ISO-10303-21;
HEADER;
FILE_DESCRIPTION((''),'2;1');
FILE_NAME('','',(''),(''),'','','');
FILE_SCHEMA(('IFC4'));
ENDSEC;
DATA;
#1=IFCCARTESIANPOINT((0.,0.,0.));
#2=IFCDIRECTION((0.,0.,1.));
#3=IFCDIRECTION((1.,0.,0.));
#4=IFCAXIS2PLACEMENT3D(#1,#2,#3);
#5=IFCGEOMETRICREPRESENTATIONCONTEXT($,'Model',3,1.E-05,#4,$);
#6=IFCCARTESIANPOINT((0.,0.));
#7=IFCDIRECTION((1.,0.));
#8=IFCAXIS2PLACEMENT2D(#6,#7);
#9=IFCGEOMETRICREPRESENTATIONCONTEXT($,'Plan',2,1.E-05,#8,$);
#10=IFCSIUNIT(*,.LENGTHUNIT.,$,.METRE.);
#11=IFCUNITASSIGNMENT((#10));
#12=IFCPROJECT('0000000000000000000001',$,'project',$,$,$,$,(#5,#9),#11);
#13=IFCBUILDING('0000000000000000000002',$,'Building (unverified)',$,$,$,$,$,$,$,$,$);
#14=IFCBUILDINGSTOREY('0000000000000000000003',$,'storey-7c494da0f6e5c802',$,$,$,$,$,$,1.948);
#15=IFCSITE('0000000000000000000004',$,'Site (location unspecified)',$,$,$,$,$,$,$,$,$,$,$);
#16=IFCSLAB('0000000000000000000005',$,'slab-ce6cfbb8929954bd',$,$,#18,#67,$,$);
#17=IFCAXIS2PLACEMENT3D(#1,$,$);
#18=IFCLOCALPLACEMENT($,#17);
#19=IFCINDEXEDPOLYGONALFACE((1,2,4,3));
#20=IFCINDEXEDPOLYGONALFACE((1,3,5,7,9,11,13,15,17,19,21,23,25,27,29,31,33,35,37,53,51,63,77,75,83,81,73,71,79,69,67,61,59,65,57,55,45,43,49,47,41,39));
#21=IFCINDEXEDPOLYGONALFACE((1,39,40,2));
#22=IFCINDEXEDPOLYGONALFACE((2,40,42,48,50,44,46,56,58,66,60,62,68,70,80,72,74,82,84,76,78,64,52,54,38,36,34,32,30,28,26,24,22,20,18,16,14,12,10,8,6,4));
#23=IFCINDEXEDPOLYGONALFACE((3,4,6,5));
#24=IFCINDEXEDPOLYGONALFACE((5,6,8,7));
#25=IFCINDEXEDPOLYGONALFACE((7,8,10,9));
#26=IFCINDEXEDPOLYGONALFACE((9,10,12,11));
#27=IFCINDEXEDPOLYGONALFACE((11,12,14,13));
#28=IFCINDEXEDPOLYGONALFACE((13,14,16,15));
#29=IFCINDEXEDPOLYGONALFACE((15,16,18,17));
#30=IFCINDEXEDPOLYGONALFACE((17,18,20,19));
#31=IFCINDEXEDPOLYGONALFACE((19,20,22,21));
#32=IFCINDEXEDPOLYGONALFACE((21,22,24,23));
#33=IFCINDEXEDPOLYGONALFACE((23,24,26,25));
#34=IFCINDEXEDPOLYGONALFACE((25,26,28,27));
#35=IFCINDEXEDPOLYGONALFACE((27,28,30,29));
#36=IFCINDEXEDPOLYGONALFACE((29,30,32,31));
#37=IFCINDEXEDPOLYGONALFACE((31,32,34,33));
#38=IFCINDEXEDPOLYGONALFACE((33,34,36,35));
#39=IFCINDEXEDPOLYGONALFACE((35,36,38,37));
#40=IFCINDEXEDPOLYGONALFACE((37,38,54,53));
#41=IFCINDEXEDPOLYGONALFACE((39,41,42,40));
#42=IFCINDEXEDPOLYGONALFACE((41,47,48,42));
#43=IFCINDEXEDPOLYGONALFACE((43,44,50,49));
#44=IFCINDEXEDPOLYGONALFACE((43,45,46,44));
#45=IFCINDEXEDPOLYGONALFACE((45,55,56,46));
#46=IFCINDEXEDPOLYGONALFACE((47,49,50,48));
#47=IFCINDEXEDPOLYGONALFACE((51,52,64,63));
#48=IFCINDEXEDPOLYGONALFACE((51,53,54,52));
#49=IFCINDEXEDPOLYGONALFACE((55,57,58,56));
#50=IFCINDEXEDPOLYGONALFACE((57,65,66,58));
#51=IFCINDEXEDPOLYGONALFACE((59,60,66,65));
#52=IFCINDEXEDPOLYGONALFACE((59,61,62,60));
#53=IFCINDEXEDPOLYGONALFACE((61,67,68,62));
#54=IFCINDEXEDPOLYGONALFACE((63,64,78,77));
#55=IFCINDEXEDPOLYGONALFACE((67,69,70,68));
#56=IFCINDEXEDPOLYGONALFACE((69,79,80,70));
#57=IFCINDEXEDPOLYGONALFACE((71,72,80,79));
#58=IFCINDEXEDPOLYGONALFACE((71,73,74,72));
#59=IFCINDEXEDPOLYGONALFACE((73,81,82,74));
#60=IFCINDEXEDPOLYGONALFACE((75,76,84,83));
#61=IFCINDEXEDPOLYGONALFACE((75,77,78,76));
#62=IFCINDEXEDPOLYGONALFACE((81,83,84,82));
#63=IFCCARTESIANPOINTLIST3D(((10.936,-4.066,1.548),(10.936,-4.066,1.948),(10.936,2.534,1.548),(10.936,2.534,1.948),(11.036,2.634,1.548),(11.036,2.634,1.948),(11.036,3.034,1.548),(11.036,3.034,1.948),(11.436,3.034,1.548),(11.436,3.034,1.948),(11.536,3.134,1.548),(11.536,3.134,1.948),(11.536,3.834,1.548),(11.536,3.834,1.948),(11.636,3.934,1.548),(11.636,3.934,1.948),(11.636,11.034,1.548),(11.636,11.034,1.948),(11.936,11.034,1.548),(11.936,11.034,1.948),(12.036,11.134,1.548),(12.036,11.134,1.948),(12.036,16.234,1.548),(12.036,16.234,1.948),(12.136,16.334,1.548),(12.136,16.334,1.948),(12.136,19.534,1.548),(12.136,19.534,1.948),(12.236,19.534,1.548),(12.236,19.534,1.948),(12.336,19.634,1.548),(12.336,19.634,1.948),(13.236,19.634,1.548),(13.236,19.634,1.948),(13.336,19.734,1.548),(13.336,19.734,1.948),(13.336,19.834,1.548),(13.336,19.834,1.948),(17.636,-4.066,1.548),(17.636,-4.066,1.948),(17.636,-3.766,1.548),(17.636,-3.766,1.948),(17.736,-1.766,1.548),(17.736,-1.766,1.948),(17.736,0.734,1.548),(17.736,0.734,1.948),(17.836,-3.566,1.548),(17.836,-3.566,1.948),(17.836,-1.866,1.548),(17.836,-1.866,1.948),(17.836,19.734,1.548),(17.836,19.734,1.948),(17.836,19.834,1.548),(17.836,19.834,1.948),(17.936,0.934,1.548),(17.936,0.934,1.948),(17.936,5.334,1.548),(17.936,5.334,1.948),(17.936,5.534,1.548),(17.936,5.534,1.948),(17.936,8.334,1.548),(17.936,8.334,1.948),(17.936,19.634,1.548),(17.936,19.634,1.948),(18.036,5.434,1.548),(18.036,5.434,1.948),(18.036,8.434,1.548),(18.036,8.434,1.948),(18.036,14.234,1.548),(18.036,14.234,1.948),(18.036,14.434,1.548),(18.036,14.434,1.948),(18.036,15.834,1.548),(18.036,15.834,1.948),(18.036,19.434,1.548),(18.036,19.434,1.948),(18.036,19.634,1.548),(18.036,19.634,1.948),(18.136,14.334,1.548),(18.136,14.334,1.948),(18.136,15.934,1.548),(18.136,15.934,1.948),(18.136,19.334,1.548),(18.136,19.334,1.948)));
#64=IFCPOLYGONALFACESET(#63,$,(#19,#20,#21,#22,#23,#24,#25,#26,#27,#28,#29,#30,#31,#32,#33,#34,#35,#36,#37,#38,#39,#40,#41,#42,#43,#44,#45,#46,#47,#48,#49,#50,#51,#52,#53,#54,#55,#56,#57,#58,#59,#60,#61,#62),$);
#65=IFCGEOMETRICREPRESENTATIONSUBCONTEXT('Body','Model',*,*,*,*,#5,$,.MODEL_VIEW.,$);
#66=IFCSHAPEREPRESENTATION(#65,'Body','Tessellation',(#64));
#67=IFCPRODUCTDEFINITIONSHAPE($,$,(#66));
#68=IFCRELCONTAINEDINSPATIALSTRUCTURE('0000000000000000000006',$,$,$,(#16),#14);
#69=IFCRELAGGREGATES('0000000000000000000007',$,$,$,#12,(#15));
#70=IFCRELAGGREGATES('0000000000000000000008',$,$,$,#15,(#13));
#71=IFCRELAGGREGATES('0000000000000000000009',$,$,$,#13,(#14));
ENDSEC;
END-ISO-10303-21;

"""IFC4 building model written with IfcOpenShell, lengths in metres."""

from ifc_helpers import new_model, si_unit, frame, origin_with_axes, origin_2d_with_axis, place, context, subcontext, project, spatial, indexed_curve, outline, extrude, element, save


model = new_model("IFC4")

# Units and contexts
model_context = context("Model", 3, precision=1e-05, world=origin_with_axes())
plan_context = context("Plan", 2, precision=1e-05, world=origin_2d_with_axis())
body_context = subcontext(model_context, "Body", "Model", "MODEL_VIEW")
ifc_project = project(units=[si_unit("LENGTHUNIT", "METRE")], contexts=[model_context, plan_context])

# Site, building, storey
site = spatial("IfcSite", under=ifc_project, Name="Site (location unspecified)")
building = spatial("IfcBuilding", under=site, Name="Building (unverified)")
storey = spatial("IfcBuildingStorey", under=building, Name="storey-7c494da0f6e5c802", Elevation=1.948)

# Slab
slab_placement = place(None, frame((0.0, 0.0, 1.548), z_axis=(0.0, 0.0, 1.0), x_axis=(1.0, 0.0, 0.0)))
element("IfcSlab", 1, at=slab_placement, inside=storey, Name="slab-ce6cfbb8929954bd", context=body_context, shape_type="SweptSolid", body=[
    extrude(outline(indexed_curve([(10.936, -4.066), (10.936, 2.534), (11.036, 2.634), (11.036, 3.034), (11.436, 3.034), (11.536, 3.134), (11.536, 3.834), (11.636, 3.934), (11.636, 11.034), (11.936, 11.034), (12.036, 11.134), (12.036, 16.234), (12.136, 16.334), (12.136, 19.534), (12.236, 19.534), (12.336, 19.634), (13.236, 19.634), (13.336, 19.734), (13.336, 19.834), (17.836, 19.834), (17.836, 19.734), (17.936, 19.634), (18.036, 19.634), (18.036, 19.434), (18.136, 19.334), (18.136, 15.934), (18.036, 15.834), (18.036, 14.434), (18.136, 14.334), (18.036, 14.234), (18.036, 8.434), (17.936, 8.334), (17.936, 5.534), (18.036, 5.434), (17.936, 5.334), (17.936, 0.934), (17.736, 0.734), (17.736, -1.766), (17.836, -1.866), (17.836, -3.566), (17.636, -3.766), (17.636, -4.066), (10.936, -4.066)])), None, (0.0, 0.0, 1.0), 0.4),
])

save(model, "model.ifc")
